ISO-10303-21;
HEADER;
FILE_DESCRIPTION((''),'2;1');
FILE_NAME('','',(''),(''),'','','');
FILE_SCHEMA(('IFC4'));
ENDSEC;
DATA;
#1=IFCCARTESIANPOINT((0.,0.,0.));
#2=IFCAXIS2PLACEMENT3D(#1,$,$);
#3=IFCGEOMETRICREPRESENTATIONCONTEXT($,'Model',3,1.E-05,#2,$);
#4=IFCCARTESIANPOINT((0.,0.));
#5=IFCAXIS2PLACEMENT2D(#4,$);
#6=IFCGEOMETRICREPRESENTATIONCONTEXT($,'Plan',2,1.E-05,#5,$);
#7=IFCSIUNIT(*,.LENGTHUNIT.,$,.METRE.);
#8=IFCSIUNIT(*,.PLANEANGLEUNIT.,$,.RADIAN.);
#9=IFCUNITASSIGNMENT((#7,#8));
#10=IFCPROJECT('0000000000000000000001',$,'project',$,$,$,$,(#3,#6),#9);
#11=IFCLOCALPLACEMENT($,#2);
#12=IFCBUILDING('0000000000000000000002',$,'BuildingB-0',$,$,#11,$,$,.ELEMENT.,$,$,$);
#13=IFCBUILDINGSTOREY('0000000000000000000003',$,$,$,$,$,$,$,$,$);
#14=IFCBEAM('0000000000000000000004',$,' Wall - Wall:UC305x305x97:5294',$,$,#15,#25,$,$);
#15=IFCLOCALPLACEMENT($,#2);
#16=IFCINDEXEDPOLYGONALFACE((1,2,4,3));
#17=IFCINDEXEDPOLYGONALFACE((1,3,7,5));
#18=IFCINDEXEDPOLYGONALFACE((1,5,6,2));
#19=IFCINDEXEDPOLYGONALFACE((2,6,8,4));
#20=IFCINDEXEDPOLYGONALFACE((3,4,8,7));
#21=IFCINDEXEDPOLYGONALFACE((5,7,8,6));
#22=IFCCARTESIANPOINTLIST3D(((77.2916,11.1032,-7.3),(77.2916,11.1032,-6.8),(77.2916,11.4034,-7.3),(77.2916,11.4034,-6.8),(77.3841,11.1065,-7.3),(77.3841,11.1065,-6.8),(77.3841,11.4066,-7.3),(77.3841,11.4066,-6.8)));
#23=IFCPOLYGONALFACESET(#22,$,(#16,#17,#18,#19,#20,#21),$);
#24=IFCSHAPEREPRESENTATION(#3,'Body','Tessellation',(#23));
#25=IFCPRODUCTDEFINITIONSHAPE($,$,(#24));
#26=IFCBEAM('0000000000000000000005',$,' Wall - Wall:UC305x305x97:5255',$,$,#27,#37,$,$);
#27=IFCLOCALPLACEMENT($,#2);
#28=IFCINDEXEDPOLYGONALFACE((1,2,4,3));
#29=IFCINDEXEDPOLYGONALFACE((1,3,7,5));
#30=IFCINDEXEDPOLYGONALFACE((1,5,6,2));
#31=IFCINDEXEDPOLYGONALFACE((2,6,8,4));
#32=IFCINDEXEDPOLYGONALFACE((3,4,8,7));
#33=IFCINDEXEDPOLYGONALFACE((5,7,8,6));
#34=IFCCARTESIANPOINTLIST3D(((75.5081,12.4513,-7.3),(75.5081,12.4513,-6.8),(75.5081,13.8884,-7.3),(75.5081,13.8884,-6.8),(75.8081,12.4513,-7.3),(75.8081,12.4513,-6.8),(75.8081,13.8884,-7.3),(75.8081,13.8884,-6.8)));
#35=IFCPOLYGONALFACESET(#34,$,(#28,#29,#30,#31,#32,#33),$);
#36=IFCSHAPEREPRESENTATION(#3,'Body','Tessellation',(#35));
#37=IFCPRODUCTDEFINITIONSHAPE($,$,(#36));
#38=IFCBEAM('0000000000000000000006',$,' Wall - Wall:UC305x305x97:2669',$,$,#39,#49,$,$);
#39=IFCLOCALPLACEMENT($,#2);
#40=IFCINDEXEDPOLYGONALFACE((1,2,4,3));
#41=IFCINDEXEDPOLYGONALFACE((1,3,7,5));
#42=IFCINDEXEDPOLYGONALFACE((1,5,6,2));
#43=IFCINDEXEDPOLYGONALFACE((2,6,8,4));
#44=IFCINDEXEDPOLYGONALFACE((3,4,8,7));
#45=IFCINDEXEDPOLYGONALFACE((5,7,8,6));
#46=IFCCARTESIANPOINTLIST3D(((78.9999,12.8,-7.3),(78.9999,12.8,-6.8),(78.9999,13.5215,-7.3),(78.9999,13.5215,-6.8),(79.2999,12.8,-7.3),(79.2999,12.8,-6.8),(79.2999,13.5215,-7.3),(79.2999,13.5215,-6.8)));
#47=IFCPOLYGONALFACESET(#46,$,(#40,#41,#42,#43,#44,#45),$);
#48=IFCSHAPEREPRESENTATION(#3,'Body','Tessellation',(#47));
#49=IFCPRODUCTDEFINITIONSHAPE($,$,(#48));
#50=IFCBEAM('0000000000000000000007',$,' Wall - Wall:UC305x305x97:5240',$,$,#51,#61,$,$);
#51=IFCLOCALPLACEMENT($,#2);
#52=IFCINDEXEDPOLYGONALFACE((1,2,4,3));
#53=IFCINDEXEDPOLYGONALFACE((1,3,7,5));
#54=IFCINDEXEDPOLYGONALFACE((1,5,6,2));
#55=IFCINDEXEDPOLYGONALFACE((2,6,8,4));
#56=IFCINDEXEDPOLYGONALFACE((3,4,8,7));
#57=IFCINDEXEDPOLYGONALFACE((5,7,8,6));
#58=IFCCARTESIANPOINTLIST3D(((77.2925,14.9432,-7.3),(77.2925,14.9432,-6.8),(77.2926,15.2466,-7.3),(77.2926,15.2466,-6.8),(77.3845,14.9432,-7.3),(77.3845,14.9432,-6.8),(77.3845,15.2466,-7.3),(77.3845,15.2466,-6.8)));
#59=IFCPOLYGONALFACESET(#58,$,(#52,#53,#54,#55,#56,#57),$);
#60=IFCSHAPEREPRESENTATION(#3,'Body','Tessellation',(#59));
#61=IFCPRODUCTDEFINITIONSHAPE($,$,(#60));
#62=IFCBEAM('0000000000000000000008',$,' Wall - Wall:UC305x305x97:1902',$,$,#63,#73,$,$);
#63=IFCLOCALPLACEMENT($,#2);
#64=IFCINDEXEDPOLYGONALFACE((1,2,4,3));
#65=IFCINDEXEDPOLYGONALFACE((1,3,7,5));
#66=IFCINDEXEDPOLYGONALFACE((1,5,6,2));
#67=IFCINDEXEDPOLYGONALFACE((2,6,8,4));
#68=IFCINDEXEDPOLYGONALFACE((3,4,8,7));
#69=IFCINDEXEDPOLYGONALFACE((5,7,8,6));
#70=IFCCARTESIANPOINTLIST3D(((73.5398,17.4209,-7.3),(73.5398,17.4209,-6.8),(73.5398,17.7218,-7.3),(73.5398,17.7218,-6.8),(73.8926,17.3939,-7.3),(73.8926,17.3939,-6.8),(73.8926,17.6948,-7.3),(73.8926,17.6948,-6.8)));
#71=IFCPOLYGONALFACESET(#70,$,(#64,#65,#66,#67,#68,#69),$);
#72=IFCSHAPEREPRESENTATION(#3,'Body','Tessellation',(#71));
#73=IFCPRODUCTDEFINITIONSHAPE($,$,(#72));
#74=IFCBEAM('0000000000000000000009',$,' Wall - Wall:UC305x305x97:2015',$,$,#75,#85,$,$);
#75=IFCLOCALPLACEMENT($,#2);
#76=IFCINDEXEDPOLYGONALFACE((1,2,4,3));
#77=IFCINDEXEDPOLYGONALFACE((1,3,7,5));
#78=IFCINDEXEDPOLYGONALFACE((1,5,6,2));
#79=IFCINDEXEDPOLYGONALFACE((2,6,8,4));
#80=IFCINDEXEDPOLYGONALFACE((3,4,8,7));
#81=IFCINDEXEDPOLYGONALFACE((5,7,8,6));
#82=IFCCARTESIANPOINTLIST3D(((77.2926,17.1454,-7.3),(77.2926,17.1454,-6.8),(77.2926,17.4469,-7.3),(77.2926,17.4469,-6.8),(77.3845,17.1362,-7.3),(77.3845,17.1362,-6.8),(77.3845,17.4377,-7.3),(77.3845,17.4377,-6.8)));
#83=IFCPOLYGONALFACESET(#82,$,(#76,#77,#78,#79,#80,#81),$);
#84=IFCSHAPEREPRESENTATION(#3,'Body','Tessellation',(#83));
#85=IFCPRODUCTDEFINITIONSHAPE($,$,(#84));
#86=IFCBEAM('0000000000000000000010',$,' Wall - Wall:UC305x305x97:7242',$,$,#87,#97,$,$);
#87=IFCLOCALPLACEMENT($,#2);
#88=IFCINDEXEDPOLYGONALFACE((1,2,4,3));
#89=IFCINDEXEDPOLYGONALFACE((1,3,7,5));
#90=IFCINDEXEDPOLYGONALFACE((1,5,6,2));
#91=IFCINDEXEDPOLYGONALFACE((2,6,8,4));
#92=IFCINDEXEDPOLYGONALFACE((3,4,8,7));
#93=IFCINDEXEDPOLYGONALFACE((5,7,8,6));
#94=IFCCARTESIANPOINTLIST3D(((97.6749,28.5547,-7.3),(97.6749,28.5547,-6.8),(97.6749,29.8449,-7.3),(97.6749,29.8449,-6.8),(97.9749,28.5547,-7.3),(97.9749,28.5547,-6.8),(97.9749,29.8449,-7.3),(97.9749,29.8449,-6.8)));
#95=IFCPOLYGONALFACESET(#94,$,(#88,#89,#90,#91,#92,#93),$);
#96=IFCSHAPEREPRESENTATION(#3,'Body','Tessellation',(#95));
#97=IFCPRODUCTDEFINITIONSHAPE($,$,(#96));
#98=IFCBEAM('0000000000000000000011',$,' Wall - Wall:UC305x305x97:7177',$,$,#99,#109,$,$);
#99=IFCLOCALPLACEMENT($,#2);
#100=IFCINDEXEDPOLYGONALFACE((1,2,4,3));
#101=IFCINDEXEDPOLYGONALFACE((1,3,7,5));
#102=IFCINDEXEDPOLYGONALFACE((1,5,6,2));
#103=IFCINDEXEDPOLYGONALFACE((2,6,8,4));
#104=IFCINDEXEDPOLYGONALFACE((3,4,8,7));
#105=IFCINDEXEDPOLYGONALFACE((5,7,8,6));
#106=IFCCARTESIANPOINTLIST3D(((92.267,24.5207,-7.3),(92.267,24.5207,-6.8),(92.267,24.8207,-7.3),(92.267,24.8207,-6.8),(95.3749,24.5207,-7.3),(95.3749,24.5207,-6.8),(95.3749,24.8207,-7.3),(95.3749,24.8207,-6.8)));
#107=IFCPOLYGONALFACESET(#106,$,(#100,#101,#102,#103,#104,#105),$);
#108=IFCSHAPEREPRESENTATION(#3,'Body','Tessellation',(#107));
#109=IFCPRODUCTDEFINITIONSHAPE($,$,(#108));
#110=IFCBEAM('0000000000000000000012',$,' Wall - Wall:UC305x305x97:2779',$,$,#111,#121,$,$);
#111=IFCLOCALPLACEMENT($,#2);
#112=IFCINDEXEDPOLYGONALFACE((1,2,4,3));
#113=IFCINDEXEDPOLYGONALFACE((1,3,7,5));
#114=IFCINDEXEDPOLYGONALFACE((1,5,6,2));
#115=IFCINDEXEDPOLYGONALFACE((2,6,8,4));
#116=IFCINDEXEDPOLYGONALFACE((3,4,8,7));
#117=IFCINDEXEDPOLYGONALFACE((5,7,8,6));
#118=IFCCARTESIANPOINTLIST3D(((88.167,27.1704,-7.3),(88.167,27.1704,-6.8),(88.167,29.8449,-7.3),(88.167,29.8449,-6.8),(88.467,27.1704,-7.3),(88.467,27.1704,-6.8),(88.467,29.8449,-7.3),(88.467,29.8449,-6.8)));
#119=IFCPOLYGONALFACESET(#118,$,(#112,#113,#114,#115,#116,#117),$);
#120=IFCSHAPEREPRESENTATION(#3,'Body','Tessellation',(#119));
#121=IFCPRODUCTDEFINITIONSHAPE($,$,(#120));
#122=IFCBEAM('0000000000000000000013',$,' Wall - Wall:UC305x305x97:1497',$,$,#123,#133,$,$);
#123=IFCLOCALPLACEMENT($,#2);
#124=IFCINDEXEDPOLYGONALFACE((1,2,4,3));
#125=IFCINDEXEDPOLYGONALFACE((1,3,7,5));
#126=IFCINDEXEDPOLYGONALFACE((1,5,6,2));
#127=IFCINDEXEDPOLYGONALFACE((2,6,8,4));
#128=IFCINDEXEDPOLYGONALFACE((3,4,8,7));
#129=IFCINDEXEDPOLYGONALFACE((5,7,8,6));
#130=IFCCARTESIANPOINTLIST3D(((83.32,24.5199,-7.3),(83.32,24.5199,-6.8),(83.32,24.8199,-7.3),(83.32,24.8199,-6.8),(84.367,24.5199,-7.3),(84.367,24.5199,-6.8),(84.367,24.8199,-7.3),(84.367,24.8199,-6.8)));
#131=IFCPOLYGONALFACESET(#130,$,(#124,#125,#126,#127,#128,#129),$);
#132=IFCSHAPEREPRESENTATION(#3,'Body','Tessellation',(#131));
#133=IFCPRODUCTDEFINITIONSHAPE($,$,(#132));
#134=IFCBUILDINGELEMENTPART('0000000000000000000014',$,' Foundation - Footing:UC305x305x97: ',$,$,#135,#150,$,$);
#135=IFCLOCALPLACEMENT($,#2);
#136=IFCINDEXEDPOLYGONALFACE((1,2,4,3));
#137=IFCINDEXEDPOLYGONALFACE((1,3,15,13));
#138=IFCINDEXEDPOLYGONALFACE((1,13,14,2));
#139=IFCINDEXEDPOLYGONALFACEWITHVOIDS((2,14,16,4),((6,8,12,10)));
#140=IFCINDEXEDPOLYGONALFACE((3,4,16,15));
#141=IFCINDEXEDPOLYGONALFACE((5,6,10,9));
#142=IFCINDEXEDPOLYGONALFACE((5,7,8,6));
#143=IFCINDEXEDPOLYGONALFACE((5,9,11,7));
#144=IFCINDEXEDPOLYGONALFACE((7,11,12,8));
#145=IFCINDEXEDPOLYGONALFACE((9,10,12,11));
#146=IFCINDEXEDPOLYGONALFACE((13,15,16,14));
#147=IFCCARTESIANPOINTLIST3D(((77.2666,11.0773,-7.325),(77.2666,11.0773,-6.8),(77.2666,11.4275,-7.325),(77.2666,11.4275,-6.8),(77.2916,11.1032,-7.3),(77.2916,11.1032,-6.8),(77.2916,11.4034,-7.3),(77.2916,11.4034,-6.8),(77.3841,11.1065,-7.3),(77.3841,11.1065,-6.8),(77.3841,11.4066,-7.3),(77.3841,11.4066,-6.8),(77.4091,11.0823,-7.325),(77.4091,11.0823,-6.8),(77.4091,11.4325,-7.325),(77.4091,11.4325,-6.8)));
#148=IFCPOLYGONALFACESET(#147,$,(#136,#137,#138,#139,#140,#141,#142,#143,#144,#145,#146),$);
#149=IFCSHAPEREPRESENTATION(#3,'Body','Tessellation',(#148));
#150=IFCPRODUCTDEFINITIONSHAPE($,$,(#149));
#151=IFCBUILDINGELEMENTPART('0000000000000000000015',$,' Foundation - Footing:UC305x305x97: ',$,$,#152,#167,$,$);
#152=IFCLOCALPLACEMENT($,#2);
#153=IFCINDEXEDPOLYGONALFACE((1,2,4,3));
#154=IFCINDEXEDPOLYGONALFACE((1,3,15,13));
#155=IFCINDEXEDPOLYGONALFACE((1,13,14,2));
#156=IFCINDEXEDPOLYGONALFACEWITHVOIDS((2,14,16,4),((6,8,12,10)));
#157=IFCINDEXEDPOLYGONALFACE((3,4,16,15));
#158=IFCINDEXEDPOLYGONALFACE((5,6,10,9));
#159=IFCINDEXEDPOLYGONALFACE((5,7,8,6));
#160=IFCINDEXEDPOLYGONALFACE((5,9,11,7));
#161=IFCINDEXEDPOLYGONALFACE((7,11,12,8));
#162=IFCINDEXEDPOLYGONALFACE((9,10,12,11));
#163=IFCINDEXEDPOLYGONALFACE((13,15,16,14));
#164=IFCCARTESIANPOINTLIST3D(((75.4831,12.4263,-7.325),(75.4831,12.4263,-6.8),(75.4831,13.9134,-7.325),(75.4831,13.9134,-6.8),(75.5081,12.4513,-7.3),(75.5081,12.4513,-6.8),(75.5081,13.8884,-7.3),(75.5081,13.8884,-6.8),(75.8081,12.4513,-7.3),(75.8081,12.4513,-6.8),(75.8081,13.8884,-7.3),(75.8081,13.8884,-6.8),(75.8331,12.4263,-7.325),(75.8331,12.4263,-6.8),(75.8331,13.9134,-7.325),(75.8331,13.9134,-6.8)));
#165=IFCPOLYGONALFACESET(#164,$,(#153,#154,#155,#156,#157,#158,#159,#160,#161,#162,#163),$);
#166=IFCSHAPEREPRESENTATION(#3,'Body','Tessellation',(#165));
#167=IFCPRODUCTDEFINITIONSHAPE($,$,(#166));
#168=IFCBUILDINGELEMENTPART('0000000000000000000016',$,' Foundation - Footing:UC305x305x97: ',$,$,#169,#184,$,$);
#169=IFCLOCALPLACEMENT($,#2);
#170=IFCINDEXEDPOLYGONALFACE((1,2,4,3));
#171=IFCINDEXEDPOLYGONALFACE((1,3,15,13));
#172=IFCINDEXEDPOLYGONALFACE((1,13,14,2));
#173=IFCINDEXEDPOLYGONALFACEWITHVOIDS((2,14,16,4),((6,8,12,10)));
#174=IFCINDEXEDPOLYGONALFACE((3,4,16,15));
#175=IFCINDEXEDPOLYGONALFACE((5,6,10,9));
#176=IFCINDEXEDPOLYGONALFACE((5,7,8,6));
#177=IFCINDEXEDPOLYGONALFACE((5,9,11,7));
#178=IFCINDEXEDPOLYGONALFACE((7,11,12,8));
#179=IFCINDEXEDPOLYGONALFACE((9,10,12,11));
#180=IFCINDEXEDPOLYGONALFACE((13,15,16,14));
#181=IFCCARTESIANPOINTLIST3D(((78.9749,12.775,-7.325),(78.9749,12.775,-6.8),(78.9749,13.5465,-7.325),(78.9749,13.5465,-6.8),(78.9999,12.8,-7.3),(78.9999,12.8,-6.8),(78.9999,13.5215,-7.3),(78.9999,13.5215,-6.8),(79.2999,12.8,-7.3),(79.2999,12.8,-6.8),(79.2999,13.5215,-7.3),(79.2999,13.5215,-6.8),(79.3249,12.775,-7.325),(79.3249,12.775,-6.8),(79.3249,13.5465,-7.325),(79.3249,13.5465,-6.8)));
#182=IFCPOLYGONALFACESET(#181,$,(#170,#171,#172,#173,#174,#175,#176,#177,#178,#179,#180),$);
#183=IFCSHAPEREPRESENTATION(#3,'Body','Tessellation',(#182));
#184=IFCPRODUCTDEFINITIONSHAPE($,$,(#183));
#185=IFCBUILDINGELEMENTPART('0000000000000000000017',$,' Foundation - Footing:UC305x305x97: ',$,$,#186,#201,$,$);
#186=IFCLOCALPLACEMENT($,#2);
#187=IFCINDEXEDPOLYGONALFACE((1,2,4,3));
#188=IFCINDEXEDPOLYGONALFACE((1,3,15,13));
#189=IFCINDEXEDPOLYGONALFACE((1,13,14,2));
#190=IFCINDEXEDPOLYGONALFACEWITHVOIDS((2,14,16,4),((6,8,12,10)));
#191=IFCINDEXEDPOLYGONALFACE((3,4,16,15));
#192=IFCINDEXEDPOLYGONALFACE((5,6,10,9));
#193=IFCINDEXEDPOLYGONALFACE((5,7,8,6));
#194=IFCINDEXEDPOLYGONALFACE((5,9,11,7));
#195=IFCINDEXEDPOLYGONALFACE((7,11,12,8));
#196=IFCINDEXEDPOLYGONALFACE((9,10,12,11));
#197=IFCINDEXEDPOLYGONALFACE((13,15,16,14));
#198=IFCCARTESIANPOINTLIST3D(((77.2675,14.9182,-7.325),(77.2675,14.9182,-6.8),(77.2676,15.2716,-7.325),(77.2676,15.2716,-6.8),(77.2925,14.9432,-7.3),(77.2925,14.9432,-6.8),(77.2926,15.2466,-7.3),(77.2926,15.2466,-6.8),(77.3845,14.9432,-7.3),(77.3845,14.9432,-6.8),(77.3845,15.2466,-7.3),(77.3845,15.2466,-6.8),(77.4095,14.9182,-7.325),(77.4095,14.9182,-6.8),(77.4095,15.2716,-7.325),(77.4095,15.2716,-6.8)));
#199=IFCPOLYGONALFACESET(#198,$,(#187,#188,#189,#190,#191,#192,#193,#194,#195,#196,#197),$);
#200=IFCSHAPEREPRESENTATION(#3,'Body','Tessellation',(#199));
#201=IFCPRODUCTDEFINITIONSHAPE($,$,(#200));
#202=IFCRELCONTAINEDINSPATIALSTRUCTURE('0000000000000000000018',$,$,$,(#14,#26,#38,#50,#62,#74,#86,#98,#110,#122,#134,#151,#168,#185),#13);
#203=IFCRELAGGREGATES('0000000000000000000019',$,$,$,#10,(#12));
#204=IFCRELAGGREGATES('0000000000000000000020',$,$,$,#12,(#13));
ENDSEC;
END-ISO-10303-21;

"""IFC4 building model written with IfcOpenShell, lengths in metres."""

from ifc_helpers import new_model, si_unit, origin, origin_2d, place, context, project, spatial, polyline, outline, extrude, element, save


model = new_model("IFC4")

# Units and contexts
model_context = context("Model", 3, precision=1e-05, world=origin())
plan_context = context("Plan", 2, precision=1e-05, world=origin_2d())
ifc_project = project(units=[si_unit("LENGTHUNIT", "METRE"), si_unit("PLANEANGLEUNIT", "RADIAN")], contexts=[model_context, plan_context])

# Building, storey
building_placement = place(None, origin())
building = spatial("IfcBuilding", under=ifc_project, at=building_placement, Name="BuildingB-0", CompositionType="ELEMENT")
storey = spatial("IfcBuildingStorey", under=building)

# Beams
element("IfcBeam", 1, inside=storey, Name=" Wall - Wall:UC305x305x97:5294", context=model_context, shape_type="SweptSolid", body=[
    extrude(outline(polyline([(77.3841, 11.1065, -7.3), (77.2916, 11.1032, -7.3), (77.2916, 11.4034, -7.3), (77.3841, 11.4066, -7.3), (77.3841, 11.1065, -7.3)])), None, (0.0, 0.0, 1.0), 0.5),
])
element("IfcBeam", 2, inside=storey, Name=" Wall - Wall:UC305x305x97:5255", context=model_context, shape_type="SweptSolid", body=[
    extrude(outline(polyline([(75.8081, 12.4513, -7.3), (75.5081, 12.4513, -7.3), (75.5081, 13.8884, -7.3), (75.8081, 13.8884, -7.3), (75.8081, 12.4513, -7.3)])), None, (0.0, 0.0, 1.0), 0.5),
])
element("IfcBeam", 3, inside=storey, Name=" Wall - Wall:UC305x305x97:2669", context=model_context, shape_type="SweptSolid", body=[
    extrude(outline(polyline([(79.2999, 12.8, -7.3), (78.9999, 12.8, -7.3), (78.9999, 13.5215, -7.3), (79.2999, 13.5215, -7.3), (79.2999, 12.8, -7.3)])), None, (0.0, 0.0, 1.0), 0.5),
])
element("IfcBeam", 4, inside=storey, Name=" Wall - Wall:UC305x305x97:5240", context=model_context, shape_type="SweptSolid", body=[
    extrude(outline(polyline([(77.3845, 14.9432, -7.3), (77.2925, 14.9432, -7.3), (77.2926, 15.2466, -7.3), (77.3845, 15.2466, -7.3), (77.3845, 14.9432, -7.3)])), None, (0.0, 0.0, 1.0), 0.5),
])
element("IfcBeam", 5, inside=storey, Name=" Wall - Wall:UC305x305x97:1902", context=model_context, shape_type="SweptSolid", body=[
    extrude(outline(polyline([(73.8926, 17.3939, -7.3), (73.5398, 17.4209, -7.3), (73.5398, 17.7218, -7.3), (73.8926, 17.6948, -7.3), (73.8926, 17.3939, -7.3)])), None, (0.0, 0.0, 1.0), 0.5),
])
element("IfcBeam", 6, inside=storey, Name=" Wall - Wall:UC305x305x97:2015", context=model_context, shape_type="SweptSolid", body=[
    extrude(outline(polyline([(77.3845, 17.1362, -7.3), (77.2926, 17.1454, -7.3), (77.2926, 17.4469, -7.3), (77.3845, 17.4377, -7.3), (77.3845, 17.1362, -7.3)])), None, (0.0, 0.0, 1.0), 0.5),
])
element("IfcBeam", 7, inside=storey, Name=" Wall - Wall:UC305x305x97:7242", context=model_context, shape_type="SweptSolid", body=[
    extrude(outline(polyline([(97.9749, 28.5547, -7.3), (97.6749, 28.5547, -7.3), (97.6749, 29.8449, -7.3), (97.9749, 29.8449, -7.3), (97.9749, 28.5547, -7.3)])), None, (0.0, 0.0, 1.0), 0.5),
])
element("IfcBeam", 8, inside=storey, Name=" Wall - Wall:UC305x305x97:7177", context=model_context, shape_type="SweptSolid", body=[
    extrude(outline(polyline([(95.3749, 24.5207, -7.3), (95.3749, 24.8207, -7.3), (92.267, 24.8207, -7.3), (92.267, 24.5207, -7.3), (95.3749, 24.5207, -7.3)])), None, (0.0, 0.0, 1.0), 0.5),
])
element("IfcBeam", 9, inside=storey, Name=" Wall - Wall:UC305x305x97:2779", context=model_context, shape_type="SweptSolid", body=[
    extrude(outline(polyline([(88.467, 27.1704, -7.3), (88.167, 27.1704, -7.3), (88.167, 29.8449, -7.3), (88.467, 29.8449, -7.3), (88.467, 27.1704, -7.3)])), None, (0.0, 0.0, 1.0), 0.5),
])
element("IfcBeam", 10, inside=storey, Name=" Wall - Wall:UC305x305x97:1497", context=model_context, shape_type="SweptSolid", body=[
    extrude(outline(polyline([(84.367, 24.5199, -7.3), (84.367, 24.8199, -7.3), (83.32, 24.8199, -7.3), (83.32, 24.5199, -7.3), (84.367, 24.5199, -7.3)])), None, (0.0, 0.0, 1.0), 0.5),
])

# Building element parts, openings
building_element_part_1 = element("IfcBuildingElementPart", 11, inside=storey, Name=" Foundation - Footing:UC305x305x97: ", context=model_context, shape_type="SweptSolid", body=[
    extrude(outline(polyline([(77.4091, 11.0823, -7.325), (77.2666, 11.0773, -7.325), (77.2666, 11.4275, -7.325), (77.4091, 11.4325, -7.325), (77.4091, 11.0823, -7.325)])), None, (0.0, 0.0, 1.0), 0.525),
])
element("IfcOpeningElement", 12, inside=storey, cuts=building_element_part_1, context=model_context, shape_type="SweptSolid", body=[
    extrude(outline(polyline([(77.3841, 11.1065, -7.3), (77.2916, 11.1032, -7.3), (77.2916, 11.4034, -7.3), (77.3841, 11.4066, -7.3), (77.3841, 11.1065, -7.3)])), None, (0.0, 0.0, 1.0), 0.5),
])
building_element_part_2 = element("IfcBuildingElementPart", 13, inside=storey, Name=" Foundation - Footing:UC305x305x97: ", context=model_context, shape_type="SweptSolid", body=[
    extrude(outline(polyline([(75.8331, 12.4263, -7.325), (75.4831, 12.4263, -7.325), (75.4831, 13.9134, -7.325), (75.8331, 13.9134, -7.325), (75.8331, 12.4263, -7.325)])), None, (0.0, 0.0, 1.0), 0.525),
])
element("IfcOpeningElement", 14, inside=storey, cuts=building_element_part_2, context=model_context, shape_type="SweptSolid", body=[
    extrude(outline(polyline([(75.8081, 12.4513, -7.3), (75.5081, 12.4513, -7.3), (75.5081, 13.8884, -7.3), (75.8081, 13.8884, -7.3), (75.8081, 12.4513, -7.3)])), None, (0.0, 0.0, 1.0), 0.5),
])
building_element_part_3 = element("IfcBuildingElementPart", 15, inside=storey, Name=" Foundation - Footing:UC305x305x97: ", context=model_context, shape_type="SweptSolid", body=[
    extrude(outline(polyline([(79.3249, 12.775, -7.325), (78.9749, 12.775, -7.325), (78.9749, 13.5465, -7.325), (79.3249, 13.5465, -7.325), (79.3249, 12.775, -7.325)])), None, (0.0, 0.0, 1.0), 0.525),
])
element("IfcOpeningElement", 16, inside=storey, cuts=building_element_part_3, context=model_context, shape_type="SweptSolid", body=[
    extrude(outline(polyline([(79.2999, 12.8, -7.3), (78.9999, 12.8, -7.3), (78.9999, 13.5215, -7.3), (79.2999, 13.5215, -7.3), (79.2999, 12.8, -7.3)])), None, (0.0, 0.0, 1.0), 0.5),
])
building_element_part_4 = element("IfcBuildingElementPart", 17, inside=storey, Name=" Foundation - Footing:UC305x305x97: ", context=model_context, shape_type="SweptSolid", body=[
    extrude(outline(polyline([(77.4095, 14.9182, -7.325), (77.2675, 14.9182, -7.325), (77.2676, 15.2716, -7.325), (77.4095, 15.2716, -7.325), (77.4095, 14.9182, -7.325)])), None, (0.0, 0.0, 1.0), 0.525),
])
element("IfcOpeningElement", 18, inside=storey, cuts=building_element_part_4, context=model_context, shape_type="SweptSolid", body=[
    extrude(outline(polyline([(77.3845, 14.9432, -7.3), (77.2925, 14.9432, -7.3), (77.2926, 15.2466, -7.3), (77.3845, 15.2466, -7.3), (77.3845, 14.9432, -7.3)])), None, (0.0, 0.0, 1.0), 0.5),
])

save(model, "model.ifc")
